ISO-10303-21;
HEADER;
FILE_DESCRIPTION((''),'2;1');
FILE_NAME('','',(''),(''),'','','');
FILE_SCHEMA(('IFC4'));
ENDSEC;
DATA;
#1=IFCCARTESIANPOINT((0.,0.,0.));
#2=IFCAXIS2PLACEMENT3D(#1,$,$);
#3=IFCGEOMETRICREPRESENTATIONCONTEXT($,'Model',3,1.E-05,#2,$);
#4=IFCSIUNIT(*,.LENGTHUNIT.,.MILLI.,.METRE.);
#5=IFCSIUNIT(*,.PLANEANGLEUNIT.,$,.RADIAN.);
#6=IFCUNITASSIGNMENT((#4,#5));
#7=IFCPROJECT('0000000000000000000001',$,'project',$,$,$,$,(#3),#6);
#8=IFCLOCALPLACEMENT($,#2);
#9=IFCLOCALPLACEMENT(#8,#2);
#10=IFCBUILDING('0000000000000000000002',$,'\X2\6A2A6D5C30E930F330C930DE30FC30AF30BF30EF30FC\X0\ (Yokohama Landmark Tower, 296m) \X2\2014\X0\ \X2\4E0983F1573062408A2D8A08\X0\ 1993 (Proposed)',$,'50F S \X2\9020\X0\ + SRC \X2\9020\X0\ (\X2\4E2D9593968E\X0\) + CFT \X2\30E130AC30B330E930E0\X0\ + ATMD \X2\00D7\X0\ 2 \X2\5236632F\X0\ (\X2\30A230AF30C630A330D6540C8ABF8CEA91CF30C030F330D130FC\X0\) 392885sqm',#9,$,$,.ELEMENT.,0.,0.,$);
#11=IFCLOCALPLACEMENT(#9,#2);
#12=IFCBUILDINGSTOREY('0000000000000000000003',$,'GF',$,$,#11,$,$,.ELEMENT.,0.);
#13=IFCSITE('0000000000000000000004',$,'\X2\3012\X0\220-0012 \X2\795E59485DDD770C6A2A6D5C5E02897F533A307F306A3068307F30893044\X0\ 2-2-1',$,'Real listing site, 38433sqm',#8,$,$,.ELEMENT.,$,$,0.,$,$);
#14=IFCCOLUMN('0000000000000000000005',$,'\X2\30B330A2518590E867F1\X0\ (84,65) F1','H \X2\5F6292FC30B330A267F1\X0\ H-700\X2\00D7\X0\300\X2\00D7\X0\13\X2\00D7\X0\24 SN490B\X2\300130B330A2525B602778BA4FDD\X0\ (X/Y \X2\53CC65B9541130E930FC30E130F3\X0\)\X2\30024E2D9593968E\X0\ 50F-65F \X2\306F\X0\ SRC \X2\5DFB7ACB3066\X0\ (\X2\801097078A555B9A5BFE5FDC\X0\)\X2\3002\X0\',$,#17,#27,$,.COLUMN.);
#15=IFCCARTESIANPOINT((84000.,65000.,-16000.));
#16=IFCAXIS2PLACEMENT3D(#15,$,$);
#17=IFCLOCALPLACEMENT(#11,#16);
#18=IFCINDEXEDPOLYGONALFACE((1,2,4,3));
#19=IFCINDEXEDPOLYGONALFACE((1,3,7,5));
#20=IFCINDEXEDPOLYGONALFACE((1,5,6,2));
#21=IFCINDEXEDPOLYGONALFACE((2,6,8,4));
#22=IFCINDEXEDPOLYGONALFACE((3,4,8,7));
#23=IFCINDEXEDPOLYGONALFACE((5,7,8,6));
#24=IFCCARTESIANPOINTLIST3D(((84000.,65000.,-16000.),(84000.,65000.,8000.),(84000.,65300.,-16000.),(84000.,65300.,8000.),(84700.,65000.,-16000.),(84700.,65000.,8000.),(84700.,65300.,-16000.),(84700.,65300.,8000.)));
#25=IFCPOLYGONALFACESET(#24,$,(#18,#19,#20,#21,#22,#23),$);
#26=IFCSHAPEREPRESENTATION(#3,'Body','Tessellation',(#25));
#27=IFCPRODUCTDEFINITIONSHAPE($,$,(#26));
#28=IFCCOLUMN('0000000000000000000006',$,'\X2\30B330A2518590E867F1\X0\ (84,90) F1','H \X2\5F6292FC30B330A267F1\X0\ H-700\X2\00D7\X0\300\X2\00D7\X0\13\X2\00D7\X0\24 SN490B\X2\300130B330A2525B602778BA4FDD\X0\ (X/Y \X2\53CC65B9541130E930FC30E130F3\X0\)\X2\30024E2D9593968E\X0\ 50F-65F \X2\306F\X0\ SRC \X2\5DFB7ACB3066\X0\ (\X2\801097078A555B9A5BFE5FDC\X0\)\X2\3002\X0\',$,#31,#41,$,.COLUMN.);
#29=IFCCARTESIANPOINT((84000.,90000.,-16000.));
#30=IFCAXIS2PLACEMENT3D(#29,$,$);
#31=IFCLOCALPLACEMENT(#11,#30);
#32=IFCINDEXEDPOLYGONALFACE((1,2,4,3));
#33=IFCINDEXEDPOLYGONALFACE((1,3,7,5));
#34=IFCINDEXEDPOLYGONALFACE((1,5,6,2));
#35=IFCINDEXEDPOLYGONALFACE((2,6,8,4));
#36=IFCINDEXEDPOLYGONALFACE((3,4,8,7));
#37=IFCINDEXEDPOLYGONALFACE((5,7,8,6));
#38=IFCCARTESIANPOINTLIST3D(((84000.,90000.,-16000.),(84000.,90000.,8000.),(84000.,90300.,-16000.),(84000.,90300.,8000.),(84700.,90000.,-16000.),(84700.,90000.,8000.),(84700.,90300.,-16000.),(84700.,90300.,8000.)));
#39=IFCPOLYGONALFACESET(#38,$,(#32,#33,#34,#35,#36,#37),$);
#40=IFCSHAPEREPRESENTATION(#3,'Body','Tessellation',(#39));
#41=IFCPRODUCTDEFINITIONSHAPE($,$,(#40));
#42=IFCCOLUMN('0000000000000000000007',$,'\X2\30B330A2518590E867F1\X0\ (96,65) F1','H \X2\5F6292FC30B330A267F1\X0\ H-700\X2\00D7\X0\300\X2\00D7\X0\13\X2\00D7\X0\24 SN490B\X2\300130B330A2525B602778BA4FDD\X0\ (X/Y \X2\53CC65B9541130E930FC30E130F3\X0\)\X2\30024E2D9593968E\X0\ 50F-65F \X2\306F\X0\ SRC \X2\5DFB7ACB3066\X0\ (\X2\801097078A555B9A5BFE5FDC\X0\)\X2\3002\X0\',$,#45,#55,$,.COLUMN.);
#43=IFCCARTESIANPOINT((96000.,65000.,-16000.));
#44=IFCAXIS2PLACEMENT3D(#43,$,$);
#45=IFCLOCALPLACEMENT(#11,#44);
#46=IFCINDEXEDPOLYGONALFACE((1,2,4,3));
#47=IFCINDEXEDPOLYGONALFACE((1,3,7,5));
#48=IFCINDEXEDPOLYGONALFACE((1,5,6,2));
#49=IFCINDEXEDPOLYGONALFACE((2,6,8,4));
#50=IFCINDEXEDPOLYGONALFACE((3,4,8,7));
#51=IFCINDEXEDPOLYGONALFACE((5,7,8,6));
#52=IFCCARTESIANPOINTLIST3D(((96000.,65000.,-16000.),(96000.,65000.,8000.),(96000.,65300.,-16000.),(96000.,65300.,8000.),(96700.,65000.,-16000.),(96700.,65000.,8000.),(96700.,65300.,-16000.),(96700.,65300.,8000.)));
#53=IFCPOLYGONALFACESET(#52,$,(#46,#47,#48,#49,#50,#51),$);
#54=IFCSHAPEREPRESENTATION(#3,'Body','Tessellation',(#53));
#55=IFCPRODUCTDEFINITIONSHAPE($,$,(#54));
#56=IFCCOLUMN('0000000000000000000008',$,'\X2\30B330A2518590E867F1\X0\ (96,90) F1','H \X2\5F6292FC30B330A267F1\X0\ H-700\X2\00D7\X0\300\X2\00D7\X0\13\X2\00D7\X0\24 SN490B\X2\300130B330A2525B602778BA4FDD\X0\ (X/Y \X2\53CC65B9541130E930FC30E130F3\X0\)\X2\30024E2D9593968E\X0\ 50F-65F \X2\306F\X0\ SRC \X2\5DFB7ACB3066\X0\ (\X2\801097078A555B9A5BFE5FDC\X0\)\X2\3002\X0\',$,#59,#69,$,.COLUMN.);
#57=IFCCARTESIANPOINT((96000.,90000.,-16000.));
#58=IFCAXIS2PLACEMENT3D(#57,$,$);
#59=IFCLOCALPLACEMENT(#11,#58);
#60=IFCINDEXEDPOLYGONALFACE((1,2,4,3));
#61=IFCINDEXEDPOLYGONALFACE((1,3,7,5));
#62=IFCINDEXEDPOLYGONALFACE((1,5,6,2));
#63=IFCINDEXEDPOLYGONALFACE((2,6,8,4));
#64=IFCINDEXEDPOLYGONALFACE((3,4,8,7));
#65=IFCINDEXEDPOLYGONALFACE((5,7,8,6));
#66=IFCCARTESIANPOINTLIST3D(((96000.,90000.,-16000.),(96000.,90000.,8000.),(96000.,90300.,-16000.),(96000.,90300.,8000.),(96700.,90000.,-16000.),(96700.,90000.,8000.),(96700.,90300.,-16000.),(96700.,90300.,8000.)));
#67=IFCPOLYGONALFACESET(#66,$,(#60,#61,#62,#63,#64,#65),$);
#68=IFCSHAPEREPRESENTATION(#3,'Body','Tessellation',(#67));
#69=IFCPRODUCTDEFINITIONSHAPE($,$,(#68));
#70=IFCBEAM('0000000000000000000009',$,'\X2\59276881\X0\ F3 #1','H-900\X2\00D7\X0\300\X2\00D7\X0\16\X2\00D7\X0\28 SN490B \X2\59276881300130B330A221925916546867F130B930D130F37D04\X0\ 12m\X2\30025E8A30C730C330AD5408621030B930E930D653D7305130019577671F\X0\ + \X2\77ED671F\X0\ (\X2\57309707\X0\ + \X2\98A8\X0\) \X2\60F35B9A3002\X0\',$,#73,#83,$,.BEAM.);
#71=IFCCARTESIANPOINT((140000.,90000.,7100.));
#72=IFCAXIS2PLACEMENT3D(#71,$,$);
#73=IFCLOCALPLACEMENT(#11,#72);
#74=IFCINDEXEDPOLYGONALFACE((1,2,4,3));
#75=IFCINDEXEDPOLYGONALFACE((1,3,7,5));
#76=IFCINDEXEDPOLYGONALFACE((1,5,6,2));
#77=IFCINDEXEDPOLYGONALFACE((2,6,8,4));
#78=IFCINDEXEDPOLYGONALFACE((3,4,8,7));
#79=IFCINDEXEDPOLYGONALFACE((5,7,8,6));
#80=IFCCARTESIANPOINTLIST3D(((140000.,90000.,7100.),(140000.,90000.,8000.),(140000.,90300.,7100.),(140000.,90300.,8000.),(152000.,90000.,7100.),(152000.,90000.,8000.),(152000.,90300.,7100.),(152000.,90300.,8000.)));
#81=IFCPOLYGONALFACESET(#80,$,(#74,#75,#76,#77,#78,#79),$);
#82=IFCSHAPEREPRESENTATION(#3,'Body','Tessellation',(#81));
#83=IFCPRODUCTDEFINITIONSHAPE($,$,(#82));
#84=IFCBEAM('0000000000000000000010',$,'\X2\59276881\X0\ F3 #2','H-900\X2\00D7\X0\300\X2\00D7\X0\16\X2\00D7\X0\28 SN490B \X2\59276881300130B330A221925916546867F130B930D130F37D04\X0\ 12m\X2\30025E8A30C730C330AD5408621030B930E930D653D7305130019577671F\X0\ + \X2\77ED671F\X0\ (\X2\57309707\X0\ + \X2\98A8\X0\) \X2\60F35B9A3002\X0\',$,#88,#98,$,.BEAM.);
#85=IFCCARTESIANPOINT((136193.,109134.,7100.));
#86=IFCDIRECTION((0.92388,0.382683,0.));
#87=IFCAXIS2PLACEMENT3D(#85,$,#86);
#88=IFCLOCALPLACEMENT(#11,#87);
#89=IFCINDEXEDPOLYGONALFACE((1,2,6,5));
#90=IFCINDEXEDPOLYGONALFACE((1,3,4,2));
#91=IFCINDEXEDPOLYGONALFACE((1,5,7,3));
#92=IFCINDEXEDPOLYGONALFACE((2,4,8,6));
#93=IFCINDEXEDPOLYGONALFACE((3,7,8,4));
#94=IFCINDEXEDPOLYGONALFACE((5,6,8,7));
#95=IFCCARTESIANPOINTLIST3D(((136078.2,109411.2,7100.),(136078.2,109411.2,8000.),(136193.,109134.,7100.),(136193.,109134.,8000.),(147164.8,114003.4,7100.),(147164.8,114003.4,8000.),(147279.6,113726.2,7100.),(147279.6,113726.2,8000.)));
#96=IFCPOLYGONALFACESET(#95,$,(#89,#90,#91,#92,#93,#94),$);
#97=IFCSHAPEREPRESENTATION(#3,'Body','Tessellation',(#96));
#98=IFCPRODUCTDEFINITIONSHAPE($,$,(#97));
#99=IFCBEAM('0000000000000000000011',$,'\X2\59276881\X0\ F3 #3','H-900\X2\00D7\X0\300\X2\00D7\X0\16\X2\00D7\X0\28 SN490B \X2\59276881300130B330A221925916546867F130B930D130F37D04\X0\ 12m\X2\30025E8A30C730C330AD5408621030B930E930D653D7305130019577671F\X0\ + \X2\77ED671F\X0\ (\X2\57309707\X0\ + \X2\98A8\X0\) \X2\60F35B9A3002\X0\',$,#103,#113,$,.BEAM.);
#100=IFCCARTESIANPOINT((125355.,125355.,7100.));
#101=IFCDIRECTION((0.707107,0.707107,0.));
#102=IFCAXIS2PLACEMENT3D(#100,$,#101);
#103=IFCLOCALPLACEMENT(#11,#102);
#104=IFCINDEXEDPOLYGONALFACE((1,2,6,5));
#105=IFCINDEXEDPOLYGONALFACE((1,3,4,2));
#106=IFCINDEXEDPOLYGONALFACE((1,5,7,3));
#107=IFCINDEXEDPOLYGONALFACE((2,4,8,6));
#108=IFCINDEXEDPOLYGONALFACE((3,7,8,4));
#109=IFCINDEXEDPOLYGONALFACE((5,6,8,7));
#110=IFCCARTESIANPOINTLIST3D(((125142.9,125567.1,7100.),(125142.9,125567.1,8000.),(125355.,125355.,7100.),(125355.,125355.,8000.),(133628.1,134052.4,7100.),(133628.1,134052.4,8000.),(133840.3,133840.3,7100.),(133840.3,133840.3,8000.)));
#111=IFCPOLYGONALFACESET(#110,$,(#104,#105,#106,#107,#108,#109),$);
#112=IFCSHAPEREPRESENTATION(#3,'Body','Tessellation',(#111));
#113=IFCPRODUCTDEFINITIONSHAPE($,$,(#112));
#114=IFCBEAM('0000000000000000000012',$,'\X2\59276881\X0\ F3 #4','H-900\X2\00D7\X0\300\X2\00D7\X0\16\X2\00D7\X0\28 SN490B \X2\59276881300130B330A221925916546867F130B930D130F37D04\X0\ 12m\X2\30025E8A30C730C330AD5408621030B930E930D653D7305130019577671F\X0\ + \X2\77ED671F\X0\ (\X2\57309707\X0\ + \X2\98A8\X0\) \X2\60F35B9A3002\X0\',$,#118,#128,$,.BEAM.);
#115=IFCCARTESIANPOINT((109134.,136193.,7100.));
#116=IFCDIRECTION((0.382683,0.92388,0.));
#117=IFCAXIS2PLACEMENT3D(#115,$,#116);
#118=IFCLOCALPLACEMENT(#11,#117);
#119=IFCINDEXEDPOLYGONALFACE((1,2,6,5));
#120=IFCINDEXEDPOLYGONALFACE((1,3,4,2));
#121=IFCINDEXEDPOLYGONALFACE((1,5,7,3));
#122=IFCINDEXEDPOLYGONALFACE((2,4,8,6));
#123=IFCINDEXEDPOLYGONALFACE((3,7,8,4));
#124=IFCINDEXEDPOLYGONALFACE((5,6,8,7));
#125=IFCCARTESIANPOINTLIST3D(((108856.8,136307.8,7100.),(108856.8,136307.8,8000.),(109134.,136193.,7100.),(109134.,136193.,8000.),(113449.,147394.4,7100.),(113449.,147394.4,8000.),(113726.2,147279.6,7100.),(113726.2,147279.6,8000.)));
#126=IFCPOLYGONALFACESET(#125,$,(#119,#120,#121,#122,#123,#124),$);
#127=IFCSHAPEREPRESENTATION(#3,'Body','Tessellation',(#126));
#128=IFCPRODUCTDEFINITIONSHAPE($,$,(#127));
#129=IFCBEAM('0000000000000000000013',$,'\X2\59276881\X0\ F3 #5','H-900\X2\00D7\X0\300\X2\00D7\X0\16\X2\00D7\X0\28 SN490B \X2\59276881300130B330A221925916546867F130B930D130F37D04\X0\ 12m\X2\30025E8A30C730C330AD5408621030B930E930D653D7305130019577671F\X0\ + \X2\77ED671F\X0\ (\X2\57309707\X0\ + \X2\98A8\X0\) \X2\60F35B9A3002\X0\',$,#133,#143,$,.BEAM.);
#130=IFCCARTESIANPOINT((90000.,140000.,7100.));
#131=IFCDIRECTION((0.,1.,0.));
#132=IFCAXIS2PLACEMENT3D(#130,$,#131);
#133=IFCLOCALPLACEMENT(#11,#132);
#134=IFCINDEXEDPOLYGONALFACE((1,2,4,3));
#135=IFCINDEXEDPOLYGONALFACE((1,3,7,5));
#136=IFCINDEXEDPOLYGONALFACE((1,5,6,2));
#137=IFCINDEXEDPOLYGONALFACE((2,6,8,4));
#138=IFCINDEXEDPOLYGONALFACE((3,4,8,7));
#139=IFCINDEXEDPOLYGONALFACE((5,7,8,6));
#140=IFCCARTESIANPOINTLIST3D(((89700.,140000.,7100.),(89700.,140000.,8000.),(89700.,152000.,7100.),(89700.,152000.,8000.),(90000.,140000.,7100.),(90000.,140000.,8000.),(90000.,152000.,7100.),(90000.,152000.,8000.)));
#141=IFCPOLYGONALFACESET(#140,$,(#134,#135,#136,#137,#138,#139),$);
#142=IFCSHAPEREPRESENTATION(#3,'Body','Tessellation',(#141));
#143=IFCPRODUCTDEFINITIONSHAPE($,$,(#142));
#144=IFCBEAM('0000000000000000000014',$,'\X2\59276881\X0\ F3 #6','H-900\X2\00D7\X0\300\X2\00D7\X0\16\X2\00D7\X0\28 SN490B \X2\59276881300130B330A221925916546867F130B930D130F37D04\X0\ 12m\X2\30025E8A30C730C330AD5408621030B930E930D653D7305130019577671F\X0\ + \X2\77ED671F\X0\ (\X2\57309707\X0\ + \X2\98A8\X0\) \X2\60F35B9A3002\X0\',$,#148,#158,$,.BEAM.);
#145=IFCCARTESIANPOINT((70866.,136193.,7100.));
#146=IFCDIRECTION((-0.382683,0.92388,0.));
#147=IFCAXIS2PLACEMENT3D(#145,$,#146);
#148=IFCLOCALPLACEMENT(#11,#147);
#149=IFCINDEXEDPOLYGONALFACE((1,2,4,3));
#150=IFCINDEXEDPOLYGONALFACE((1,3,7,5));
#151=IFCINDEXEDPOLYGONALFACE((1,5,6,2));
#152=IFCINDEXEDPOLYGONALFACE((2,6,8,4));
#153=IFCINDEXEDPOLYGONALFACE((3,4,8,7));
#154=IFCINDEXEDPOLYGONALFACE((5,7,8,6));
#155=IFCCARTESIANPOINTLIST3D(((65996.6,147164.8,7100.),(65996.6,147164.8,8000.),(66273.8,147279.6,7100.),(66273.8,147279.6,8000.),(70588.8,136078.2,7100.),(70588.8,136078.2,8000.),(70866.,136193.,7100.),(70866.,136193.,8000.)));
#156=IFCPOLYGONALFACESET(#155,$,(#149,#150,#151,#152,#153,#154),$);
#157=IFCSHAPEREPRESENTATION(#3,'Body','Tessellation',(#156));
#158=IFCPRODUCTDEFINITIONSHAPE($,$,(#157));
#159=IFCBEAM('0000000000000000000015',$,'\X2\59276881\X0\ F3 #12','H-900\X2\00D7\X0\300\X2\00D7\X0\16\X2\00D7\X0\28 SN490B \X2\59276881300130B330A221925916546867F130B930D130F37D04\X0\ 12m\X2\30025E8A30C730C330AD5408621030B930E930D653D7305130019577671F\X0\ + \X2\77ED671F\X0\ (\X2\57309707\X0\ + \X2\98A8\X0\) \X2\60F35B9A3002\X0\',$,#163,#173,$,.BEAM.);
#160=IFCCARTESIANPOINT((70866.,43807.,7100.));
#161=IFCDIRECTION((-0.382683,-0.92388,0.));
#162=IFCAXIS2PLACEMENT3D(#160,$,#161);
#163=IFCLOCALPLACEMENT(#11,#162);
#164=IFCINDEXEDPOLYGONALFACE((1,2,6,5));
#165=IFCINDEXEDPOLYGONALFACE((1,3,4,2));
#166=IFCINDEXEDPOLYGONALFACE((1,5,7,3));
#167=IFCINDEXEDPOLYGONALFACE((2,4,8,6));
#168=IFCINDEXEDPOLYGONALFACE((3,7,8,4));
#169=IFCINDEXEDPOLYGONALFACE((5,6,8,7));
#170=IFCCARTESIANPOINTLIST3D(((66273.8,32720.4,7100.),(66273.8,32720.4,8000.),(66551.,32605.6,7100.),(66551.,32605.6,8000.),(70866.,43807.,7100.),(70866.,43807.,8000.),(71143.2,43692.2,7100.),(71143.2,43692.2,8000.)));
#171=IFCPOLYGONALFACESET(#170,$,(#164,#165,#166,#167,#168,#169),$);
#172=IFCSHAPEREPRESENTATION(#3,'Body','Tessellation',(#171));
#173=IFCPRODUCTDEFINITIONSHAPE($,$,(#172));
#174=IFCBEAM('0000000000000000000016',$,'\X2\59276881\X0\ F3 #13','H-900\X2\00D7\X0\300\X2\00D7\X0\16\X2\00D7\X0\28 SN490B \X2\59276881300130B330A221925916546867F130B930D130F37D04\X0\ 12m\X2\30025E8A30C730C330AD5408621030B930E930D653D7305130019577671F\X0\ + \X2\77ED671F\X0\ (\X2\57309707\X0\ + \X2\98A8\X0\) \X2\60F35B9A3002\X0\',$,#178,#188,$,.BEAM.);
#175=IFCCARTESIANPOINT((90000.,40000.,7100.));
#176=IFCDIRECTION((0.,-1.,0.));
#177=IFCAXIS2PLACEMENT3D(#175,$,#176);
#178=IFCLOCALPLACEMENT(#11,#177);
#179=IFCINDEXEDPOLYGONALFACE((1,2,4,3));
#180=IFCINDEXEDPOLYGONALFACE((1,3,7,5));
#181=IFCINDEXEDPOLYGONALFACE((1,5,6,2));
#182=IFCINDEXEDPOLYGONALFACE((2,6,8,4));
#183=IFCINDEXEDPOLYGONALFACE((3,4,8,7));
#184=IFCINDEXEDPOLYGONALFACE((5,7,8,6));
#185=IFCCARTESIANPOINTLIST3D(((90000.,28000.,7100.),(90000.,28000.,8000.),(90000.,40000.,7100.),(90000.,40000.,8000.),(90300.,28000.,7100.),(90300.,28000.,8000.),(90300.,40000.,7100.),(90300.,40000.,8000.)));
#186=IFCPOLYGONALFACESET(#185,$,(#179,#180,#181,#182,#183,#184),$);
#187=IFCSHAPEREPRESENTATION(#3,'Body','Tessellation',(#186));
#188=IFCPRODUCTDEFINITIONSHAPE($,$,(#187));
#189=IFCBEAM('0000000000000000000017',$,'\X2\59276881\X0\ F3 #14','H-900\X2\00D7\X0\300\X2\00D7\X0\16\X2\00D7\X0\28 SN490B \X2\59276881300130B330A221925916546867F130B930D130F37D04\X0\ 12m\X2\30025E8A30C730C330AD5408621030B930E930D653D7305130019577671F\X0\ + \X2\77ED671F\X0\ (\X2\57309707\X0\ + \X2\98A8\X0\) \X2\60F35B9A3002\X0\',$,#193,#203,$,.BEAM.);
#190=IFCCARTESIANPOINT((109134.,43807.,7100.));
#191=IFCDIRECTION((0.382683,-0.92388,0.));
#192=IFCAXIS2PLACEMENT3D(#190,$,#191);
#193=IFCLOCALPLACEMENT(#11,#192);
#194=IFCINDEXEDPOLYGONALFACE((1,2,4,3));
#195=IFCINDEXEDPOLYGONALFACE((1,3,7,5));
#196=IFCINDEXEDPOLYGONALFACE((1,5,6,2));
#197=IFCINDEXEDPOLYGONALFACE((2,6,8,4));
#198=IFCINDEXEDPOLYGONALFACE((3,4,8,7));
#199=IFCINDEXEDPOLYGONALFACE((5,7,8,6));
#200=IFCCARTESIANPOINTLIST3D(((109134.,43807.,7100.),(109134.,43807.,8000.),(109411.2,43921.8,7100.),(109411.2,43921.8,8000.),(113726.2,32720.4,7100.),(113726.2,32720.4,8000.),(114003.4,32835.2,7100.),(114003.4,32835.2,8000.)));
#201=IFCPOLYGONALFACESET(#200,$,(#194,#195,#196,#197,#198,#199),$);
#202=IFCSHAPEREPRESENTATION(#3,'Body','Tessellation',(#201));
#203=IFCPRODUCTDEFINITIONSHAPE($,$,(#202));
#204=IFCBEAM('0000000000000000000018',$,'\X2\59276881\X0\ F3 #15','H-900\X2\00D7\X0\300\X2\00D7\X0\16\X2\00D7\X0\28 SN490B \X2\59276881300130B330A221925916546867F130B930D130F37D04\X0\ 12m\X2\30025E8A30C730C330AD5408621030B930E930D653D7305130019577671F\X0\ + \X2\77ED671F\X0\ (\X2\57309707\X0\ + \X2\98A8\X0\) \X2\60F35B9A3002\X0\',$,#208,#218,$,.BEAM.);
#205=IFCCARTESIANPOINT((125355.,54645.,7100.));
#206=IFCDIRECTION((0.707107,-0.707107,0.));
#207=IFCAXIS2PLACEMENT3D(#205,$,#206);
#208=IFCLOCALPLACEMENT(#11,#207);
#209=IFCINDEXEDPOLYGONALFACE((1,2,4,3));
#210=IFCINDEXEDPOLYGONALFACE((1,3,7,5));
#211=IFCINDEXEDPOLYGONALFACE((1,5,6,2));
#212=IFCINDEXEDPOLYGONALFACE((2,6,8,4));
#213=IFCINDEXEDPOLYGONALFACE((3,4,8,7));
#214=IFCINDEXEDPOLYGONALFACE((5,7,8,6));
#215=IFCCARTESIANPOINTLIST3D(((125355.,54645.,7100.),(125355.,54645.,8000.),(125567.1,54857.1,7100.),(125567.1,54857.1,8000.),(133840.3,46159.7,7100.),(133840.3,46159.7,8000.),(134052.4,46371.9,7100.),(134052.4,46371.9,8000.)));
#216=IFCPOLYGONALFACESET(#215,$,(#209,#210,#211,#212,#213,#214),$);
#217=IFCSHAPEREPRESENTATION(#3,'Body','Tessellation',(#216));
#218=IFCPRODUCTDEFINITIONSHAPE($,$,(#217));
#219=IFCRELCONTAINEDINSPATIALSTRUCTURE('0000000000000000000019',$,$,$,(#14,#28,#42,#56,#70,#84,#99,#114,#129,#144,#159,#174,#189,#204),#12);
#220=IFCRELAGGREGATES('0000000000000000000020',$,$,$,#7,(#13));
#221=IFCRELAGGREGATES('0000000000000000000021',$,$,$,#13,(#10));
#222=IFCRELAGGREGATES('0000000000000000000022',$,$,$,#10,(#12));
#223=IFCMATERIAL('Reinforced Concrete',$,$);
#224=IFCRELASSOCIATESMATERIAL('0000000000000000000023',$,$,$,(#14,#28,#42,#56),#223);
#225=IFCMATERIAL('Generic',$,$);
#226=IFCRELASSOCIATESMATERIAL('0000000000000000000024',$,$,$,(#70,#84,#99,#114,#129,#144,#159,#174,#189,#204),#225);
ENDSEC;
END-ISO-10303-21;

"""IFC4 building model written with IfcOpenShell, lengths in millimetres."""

from ifc_helpers import new_model, si_unit, frame, frame_2d, origin, place, context, project, spatial, rectangle, extrude, material, element, save


model = new_model("IFC4")

# Units and contexts
model_context = context("Model", 3, precision=1e-05, world=origin())
ifc_project = project(units=[si_unit("LENGTHUNIT", "METRE", prefix="MILLI"), si_unit("PLANEANGLEUNIT", "RADIAN")], contexts=[model_context])

# Site, building, storey
site_placement = place(None, origin())
site = spatial("IfcSite", under=ifc_project, at=site_placement, Name="〒220-0012 神奈川県横浜市西区みなとみらい 2-2-1", ObjectType="Real listing site, 38433sqm", CompositionType="ELEMENT", RefElevation=0.0)
building_placement = place(site_placement, origin())
building = spatial("IfcBuilding", under=site, at=building_placement, Name="横浜ランドマークタワー (Yokohama Landmark Tower, 296m) — 三菱地所設計 1993 (Proposed)", ObjectType="50F S 造 + SRC 造 (中間階) + CFT メガコラム + ATMD × 2 制振 (アクティブ同調質量ダンパー) 392885sqm", CompositionType="ELEMENT", ElevationOfRefHeight=0.0, ElevationOfTerrain=0.0)
storey_placement = place(building_placement, origin())
storey = spatial("IfcBuildingStorey", under=building, at=storey_placement, Name="GF", CompositionType="ELEMENT", Elevation=0.0)

# Shared definitions
ifc_material_1 = material(Name="Reinforced Concrete")

# Columns
column_1_placement = place(storey_placement, frame((84000.0, 65000.0, -16000.0)))
element("IfcColumn", 1, at=column_1_placement, inside=storey, material=ifc_material_1, Name="コア内部柱 (84,65) F1", Description="H 形鋼コア柱 H-700×300×13×24 SN490B、コア剛性確保 (X/Y 双方向ラーメン)。中間階 50F-65F は SRC 巻立て (耐震評定対応)。", PredefinedType="COLUMN", context=model_context, shape_type="SweptSolid", body=[
    extrude(rectangle(XDim=700.0, YDim=300.0, at=frame_2d((350.0, 150.0))), frame((84000.0, 65000.0, -16000.0)), (0.0, 0.0, 1.0), 24000.0),
])
column_2_placement = place(storey_placement, frame((84000.0, 90000.0, -16000.0)))
element("IfcColumn", 2, at=column_2_placement, inside=storey, material=ifc_material_1, Name="コア内部柱 (84,90) F1", Description="H 形鋼コア柱 H-700×300×13×24 SN490B、コア剛性確保 (X/Y 双方向ラーメン)。中間階 50F-65F は SRC 巻立て (耐震評定対応)。", PredefinedType="COLUMN", context=model_context, shape_type="SweptSolid", body=[
    extrude(rectangle(XDim=700.0, YDim=300.0, at=frame_2d((350.0, 150.0))), frame((84000.0, 90000.0, -16000.0)), (0.0, 0.0, 1.0), 24000.0),
])
column_3_placement = place(storey_placement, frame((96000.0, 65000.0, -16000.0)))
element("IfcColumn", 3, at=column_3_placement, inside=storey, material=ifc_material_1, Name="コア内部柱 (96,65) F1", Description="H 形鋼コア柱 H-700×300×13×24 SN490B、コア剛性確保 (X/Y 双方向ラーメン)。中間階 50F-65F は SRC 巻立て (耐震評定対応)。", PredefinedType="COLUMN", context=model_context, shape_type="SweptSolid", body=[
    extrude(rectangle(XDim=700.0, YDim=300.0, at=frame_2d((350.0, 150.0))), frame((96000.0, 65000.0, -16000.0)), (0.0, 0.0, 1.0), 24000.0),
])
column_4_placement = place(storey_placement, frame((96000.0, 90000.0, -16000.0)))
element("IfcColumn", 4, at=column_4_placement, inside=storey, material=ifc_material_1, Name="コア内部柱 (96,90) F1", Description="H 形鋼コア柱 H-700×300×13×24 SN490B、コア剛性確保 (X/Y 双方向ラーメン)。中間階 50F-65F は SRC 巻立て (耐震評定対応)。", PredefinedType="COLUMN", context=model_context, shape_type="SweptSolid", body=[
    extrude(rectangle(XDim=700.0, YDim=300.0, at=frame_2d((350.0, 150.0))), frame((96000.0, 90000.0, -16000.0)), (0.0, 0.0, 1.0), 24000.0),
])

# Beams
ifc_material_2 = material(Name="Generic")
beam_1_placement = place(storey_placement, frame((140000.0, 90000.0, 7100.0)))
element("IfcBeam", 5, at=beam_1_placement, inside=storey, material=ifc_material_2, Name="大梁 F3 #1", Description="H-900×300×16×28 SN490B 大梁、コア→外周柱スパン約 12m。床デッキ合成スラブ受け、長期 + 短期 (地震 + 風) 想定。", PredefinedType="BEAM", context=model_context, shape_type="SweptSolid", body=[
    extrude(rectangle(XDim=12000.0, YDim=300.0, at=frame_2d((6000.0, 150.0))), frame((140000.0, 90000.0, 7100.0)), (0.0, 0.0, 1.0), 900.0),
])
beam_2_placement = place(storey_placement, frame((136193.0, 109134.0, 7100.0), x_axis=(0.92388, 0.382683, 0.0)))
element("IfcBeam", 6, at=beam_2_placement, inside=storey, material=ifc_material_2, Name="大梁 F3 #2", Description="H-900×300×16×28 SN490B 大梁、コア→外周柱スパン約 12m。床デッキ合成スラブ受け、長期 + 短期 (地震 + 風) 想定。", PredefinedType="BEAM", context=model_context, shape_type="SweptSolid", body=[
    extrude(rectangle(XDim=12000.0, YDim=300.0, at=frame_2d((6000.0, 150.0))), frame((136193.0, 109134.0, 7100.0), x_axis=(0.92388, 0.382683, 0.0)), (0.0, 0.0, 1.0), 900.0),
])
beam_3_placement = place(storey_placement, frame((125355.0, 125355.0, 7100.0), x_axis=(0.707107, 0.707107, 0.0)))
element("IfcBeam", 7, at=beam_3_placement, inside=storey, material=ifc_material_2, Name="大梁 F3 #3", Description="H-900×300×16×28 SN490B 大梁、コア→外周柱スパン約 12m。床デッキ合成スラブ受け、長期 + 短期 (地震 + 風) 想定。", PredefinedType="BEAM", context=model_context, shape_type="SweptSolid", body=[
    extrude(rectangle(XDim=12000.0, YDim=300.0, at=frame_2d((6000.0, 150.0))), frame((125355.0, 125355.0, 7100.0), x_axis=(0.707107, 0.707107, 0.0)), (0.0, 0.0, 1.0), 900.0),
])
beam_4_placement = place(storey_placement, frame((109134.0, 136193.0, 7100.0), x_axis=(0.382683, 0.92388, 0.0)))
element("IfcBeam", 8, at=beam_4_placement, inside=storey, material=ifc_material_2, Name="大梁 F3 #4", Description="H-900×300×16×28 SN490B 大梁、コア→外周柱スパン約 12m。床デッキ合成スラブ受け、長期 + 短期 (地震 + 風) 想定。", PredefinedType="BEAM", context=model_context, shape_type="SweptSolid", body=[
    extrude(rectangle(XDim=12000.0, YDim=300.0, at=frame_2d((6000.0, 150.0))), frame((109134.0, 136193.0, 7100.0), x_axis=(0.382683, 0.92388, 0.0)), (0.0, 0.0, 1.0), 900.0),
])
beam_5_placement = place(storey_placement, frame((90000.0, 140000.0, 7100.0), x_axis=(0.0, 1.0, 0.0)))
element("IfcBeam", 9, at=beam_5_placement, inside=storey, material=ifc_material_2, Name="大梁 F3 #5", Description="H-900×300×16×28 SN490B 大梁、コア→外周柱スパン約 12m。床デッキ合成スラブ受け、長期 + 短期 (地震 + 風) 想定。", PredefinedType="BEAM", context=model_context, shape_type="SweptSolid", body=[
    extrude(rectangle(XDim=12000.0, YDim=300.0, at=frame_2d((6000.0, 150.0))), frame((90000.0, 140000.0, 7100.0), x_axis=(0.0, 1.0, 0.0)), (0.0, 0.0, 1.0), 900.0),
])
beam_6_placement = place(storey_placement, frame((70866.0, 136193.0, 7100.0), x_axis=(-0.382683, 0.92388, 0.0)))
element("IfcBeam", 10, at=beam_6_placement, inside=storey, material=ifc_material_2, Name="大梁 F3 #6", Description="H-900×300×16×28 SN490B 大梁、コア→外周柱スパン約 12m。床デッキ合成スラブ受け、長期 + 短期 (地震 + 風) 想定。", PredefinedType="BEAM", context=model_context, shape_type="SweptSolid", body=[
    extrude(rectangle(XDim=12000.0, YDim=300.0, at=frame_2d((6000.0, 150.0))), frame((70866.0, 136193.0, 7100.0), x_axis=(-0.382683, 0.92388, 0.0)), (0.0, 0.0, 1.0), 900.0),
])
beam_7_placement = place(storey_placement, frame((70866.0, 43807.0, 7100.0), x_axis=(-0.382683, -0.92388, 0.0)))
element("IfcBeam", 11, at=beam_7_placement, inside=storey, material=ifc_material_2, Name="大梁 F3 #12", Description="H-900×300×16×28 SN490B 大梁、コア→外周柱スパン約 12m。床デッキ合成スラブ受け、長期 + 短期 (地震 + 風) 想定。", PredefinedType="BEAM", context=model_context, shape_type="SweptSolid", body=[
    extrude(rectangle(XDim=12000.0, YDim=300.0, at=frame_2d((6000.0, 150.0))), frame((70866.0, 43807.0, 7100.0), x_axis=(-0.382683, -0.92388, 0.0)), (0.0, 0.0, 1.0), 900.0),
])
beam_8_placement = place(storey_placement, frame((90000.0, 40000.0, 7100.0), x_axis=(0.0, -1.0, 0.0)))
element("IfcBeam", 12, at=beam_8_placement, inside=storey, material=ifc_material_2, Name="大梁 F3 #13", Description="H-900×300×16×28 SN490B 大梁、コア→外周柱スパン約 12m。床デッキ合成スラブ受け、長期 + 短期 (地震 + 風) 想定。", PredefinedType="BEAM", context=model_context, shape_type="SweptSolid", body=[
    extrude(rectangle(XDim=12000.0, YDim=300.0, at=frame_2d((6000.0, 150.0))), frame((90000.0, 40000.0, 7100.0), x_axis=(0.0, -1.0, 0.0)), (0.0, 0.0, 1.0), 900.0),
])
beam_9_placement = place(storey_placement, frame((109134.0, 43807.0, 7100.0), x_axis=(0.382683, -0.92388, 0.0)))
element("IfcBeam", 13, at=beam_9_placement, inside=storey, material=ifc_material_2, Name="大梁 F3 #14", Description="H-900×300×16×28 SN490B 大梁、コア→外周柱スパン約 12m。床デッキ合成スラブ受け、長期 + 短期 (地震 + 風) 想定。", PredefinedType="BEAM", context=model_context, shape_type="SweptSolid", body=[
    extrude(rectangle(XDim=12000.0, YDim=300.0, at=frame_2d((6000.0, 150.0))), frame((109134.0, 43807.0, 7100.0), x_axis=(0.382683, -0.92388, 0.0)), (0.0, 0.0, 1.0), 900.0),
])
beam_10_placement = place(storey_placement, frame((125355.0, 54645.0, 7100.0), x_axis=(0.707107, -0.707107, 0.0)))
element("IfcBeam", 14, at=beam_10_placement, inside=storey, material=ifc_material_2, Name="大梁 F3 #15", Description="H-900×300×16×28 SN490B 大梁、コア→外周柱スパン約 12m。床デッキ合成スラブ受け、長期 + 短期 (地震 + 風) 想定。", PredefinedType="BEAM", context=model_context, shape_type="SweptSolid", body=[
    extrude(rectangle(XDim=12000.0, YDim=300.0, at=frame_2d((6000.0, 150.0))), frame((125355.0, 54645.0, 7100.0), x_axis=(0.707107, -0.707107, 0.0)), (0.0, 0.0, 1.0), 900.0),
])

save(model, "model.ifc")
